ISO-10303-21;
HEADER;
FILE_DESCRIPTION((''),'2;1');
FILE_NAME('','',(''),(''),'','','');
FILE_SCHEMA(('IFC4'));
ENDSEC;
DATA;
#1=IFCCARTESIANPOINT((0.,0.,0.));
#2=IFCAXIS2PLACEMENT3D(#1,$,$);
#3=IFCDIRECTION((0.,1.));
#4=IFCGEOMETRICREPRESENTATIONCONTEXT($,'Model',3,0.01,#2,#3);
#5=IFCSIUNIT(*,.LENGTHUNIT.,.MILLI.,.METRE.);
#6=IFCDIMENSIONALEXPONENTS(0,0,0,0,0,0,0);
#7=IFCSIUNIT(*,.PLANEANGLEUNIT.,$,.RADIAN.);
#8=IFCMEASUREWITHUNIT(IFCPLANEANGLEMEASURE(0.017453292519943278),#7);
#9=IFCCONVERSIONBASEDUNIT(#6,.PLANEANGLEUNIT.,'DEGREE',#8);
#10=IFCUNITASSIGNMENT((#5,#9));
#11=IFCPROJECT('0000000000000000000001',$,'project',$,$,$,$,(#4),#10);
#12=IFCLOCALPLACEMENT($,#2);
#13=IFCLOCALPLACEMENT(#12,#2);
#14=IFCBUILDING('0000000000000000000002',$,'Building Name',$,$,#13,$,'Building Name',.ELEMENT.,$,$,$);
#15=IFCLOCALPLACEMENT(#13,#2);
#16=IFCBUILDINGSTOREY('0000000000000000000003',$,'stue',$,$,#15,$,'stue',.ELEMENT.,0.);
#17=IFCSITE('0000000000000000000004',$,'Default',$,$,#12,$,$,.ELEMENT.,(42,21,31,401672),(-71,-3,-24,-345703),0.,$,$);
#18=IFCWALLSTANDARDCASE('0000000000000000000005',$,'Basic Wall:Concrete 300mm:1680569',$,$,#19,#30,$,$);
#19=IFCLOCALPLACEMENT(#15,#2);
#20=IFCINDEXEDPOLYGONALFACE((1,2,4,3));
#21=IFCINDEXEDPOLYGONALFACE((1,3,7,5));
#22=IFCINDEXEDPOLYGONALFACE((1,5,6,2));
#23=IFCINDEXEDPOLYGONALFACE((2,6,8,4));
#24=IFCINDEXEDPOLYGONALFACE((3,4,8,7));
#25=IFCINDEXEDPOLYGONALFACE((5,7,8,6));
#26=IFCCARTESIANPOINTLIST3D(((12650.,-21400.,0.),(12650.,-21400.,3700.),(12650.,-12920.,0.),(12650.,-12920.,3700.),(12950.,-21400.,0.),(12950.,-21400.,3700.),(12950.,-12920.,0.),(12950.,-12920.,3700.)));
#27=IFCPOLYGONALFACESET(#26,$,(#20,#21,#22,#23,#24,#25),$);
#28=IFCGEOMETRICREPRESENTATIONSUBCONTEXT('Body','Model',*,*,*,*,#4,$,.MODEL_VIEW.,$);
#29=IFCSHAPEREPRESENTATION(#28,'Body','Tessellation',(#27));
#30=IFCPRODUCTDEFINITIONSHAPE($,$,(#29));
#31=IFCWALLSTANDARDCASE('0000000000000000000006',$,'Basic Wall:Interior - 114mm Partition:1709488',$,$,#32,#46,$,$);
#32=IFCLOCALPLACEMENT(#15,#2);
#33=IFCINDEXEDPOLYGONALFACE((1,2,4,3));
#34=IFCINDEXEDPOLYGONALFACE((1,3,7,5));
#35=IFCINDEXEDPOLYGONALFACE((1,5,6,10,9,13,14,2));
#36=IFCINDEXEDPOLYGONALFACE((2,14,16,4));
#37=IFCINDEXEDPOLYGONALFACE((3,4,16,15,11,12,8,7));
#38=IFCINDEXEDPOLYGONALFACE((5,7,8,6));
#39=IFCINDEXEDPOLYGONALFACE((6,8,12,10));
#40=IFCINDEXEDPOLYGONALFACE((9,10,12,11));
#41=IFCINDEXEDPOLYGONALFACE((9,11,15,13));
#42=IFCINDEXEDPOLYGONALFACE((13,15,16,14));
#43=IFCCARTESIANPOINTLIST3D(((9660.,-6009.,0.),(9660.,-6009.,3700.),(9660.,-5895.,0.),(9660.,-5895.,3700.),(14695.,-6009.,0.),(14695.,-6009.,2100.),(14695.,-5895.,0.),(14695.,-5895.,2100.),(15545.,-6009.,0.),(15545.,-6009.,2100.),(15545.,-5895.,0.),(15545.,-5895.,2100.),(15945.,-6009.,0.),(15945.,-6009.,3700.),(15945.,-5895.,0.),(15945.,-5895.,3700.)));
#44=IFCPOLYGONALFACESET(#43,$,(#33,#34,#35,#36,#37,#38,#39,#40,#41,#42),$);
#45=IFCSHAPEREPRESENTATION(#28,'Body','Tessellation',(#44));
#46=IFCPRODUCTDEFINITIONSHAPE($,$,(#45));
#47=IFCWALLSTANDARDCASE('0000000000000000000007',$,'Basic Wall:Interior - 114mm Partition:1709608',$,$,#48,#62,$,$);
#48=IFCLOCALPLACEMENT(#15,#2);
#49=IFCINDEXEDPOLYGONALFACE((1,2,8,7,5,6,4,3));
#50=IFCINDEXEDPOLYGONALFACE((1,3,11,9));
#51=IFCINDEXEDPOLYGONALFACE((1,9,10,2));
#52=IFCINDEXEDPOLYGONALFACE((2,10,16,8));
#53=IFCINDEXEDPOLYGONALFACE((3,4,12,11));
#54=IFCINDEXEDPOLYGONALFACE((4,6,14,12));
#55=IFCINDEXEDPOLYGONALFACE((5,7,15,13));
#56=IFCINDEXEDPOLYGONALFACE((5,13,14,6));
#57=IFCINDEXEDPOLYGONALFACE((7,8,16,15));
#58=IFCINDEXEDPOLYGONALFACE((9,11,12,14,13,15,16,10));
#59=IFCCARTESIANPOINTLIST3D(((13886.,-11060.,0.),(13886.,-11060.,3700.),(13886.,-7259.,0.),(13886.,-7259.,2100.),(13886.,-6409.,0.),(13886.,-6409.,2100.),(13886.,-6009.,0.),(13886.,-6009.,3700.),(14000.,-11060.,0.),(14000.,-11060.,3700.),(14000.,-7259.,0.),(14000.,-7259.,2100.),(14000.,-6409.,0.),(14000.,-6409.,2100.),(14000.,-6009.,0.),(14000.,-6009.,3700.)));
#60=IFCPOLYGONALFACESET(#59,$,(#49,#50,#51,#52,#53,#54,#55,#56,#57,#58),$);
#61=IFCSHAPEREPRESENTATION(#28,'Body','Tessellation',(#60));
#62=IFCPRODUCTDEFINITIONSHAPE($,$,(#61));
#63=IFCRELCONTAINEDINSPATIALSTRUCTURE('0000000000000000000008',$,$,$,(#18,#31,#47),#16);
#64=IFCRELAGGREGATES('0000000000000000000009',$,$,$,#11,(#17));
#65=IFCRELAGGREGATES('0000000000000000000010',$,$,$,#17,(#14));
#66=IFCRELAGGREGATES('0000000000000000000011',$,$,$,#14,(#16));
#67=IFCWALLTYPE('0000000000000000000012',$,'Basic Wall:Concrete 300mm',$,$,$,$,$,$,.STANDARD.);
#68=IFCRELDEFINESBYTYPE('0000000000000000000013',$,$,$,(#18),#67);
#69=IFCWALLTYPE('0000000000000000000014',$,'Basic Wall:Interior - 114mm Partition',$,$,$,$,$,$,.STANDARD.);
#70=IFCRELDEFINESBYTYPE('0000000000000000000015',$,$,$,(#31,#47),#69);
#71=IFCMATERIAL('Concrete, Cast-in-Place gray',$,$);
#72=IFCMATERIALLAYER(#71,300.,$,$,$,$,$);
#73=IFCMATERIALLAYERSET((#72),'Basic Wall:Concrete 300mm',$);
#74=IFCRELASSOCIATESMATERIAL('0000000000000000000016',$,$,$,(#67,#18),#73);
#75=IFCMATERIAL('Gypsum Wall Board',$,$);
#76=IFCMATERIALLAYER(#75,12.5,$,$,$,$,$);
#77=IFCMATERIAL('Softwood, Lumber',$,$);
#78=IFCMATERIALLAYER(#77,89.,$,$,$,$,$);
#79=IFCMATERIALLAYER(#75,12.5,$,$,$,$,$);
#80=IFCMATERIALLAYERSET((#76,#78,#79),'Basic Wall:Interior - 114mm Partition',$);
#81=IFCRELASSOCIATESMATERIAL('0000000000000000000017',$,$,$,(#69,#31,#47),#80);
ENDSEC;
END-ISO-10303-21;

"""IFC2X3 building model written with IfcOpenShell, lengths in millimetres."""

from ifc_helpers import new_model, entity, si_unit, converted_unit, direction, frame, frame_2d, origin, place, context, subcontext, project, spatial, polyline, rectangle, extrude, clip, bounded_halfspace, material, layer, layer_set, layer_usage, type_object, element, save


model = new_model("IFC2X3")

# Units and contexts
model_context = context("Model", 3, precision=0.01, world=origin(), true_north=direction((0.0, 1.0)))
body_context = subcontext(model_context, "Body", "Model", "MODEL_VIEW")
ifc_project = project(units=[si_unit("LENGTHUNIT", "METRE", prefix="MILLI"), converted_unit("PLANEANGLEUNIT", "DEGREE", entity("IfcPlaneAngleMeasure", 0.017453292519943278), si_unit("PLANEANGLEUNIT", "RADIAN"), dimensions=[0, 0, 0, 0, 0, 0, 0])], contexts=[model_context])

# Site, building, storey
site_placement = place(None, origin())
site = spatial("IfcSite", under=ifc_project, at=site_placement, Name="Default", CompositionType="ELEMENT", RefLatitude=(42, 21, 31, 401672), RefLongitude=(-71, -3, -24, -345703), RefElevation=0.0)
building_placement = place(site_placement, origin())
building = spatial("IfcBuilding", under=site, at=building_placement, Name="Building Name", LongName="Building Name", CompositionType="ELEMENT")
storey_placement = place(building_placement, origin())
storey = spatial("IfcBuildingStorey", under=building, at=storey_placement, Name="stue", LongName="stue", CompositionType="ELEMENT", Elevation=0.0)

# Shared definitions
ifc_material_1 = material(Name="Concrete, Cast-in-Place gray")

# Wall
ifc_layer_1 = layer(ifc_material_1, 300.0)
ifc_layer_set_1 = layer_set([ifc_layer_1], Name="Basic Wall:Concrete 300mm")
ifc_layer_usage_1 = layer_usage(ifc_layer_set_1, "AXIS2", "NEGATIVE", 150.0)
wall_type_1 = type_object("IfcWallType", Name="Basic Wall:Concrete 300mm", PredefinedType="STANDARD", material=ifc_layer_set_1)
wall_1_placement = place(storey_placement, frame((12800.0, -12920.0, 0.0), z_axis=(0.0, 0.0, 1.0), x_axis=(0.0, -1.0, 0.0)))
element("IfcWallStandardCase", 1, at=wall_1_placement, inside=storey, type_object=wall_type_1, material=ifc_layer_usage_1, Name="Basic Wall:Concrete 300mm:1680569", context=body_context, shape_type="Clipping", body=[
    clip(clip(extrude(rectangle(XDim=8480.0, YDim=300.0, at=frame_2d((4240.0, 0.0), x_axis=(-1.0, 0.0))), origin(), (0.0, 0.0, 1.0), 3700.0), bounded_halfspace(frame((0.0, -150.0, 3700.0), z_axis=(0.0, 0.0, -1.0), x_axis=(1.0, 0.0, 0.0)), True, frame((0.0, -150.0, 3700.0)), polyline([(0.0, 0.0), (130.0, 0.0), (130.0, 300.0), (0.0, 300.0), (0.0, 0.0)]))), bounded_halfspace(frame((130.0, -150.0, 3700.0), z_axis=(0.0, 0.0, -1.0), x_axis=(0.0, -1.0, 0.0)), True, frame((130.0, -150.0, 3700.0)), polyline([(0.0, 0.0), (8350.0, 0.0), (8350.0, 300.0), (0.0, 300.0), (0.0, 0.0)]))),
])

# Walls, openings
ifc_material_2 = material(Name="Gypsum Wall Board")
ifc_layer_2 = layer(ifc_material_2, 12.5)
ifc_material_3 = material(Name="Softwood, Lumber")
ifc_layer_3 = layer(ifc_material_3, 89.0)
ifc_layer_4 = layer(ifc_material_2, 12.5)
ifc_layer_set_2 = layer_set([ifc_layer_2, ifc_layer_3, ifc_layer_4], Name="Basic Wall:Interior - 114mm Partition")
ifc_layer_usage_2 = layer_usage(ifc_layer_set_2, "AXIS2", "NEGATIVE", 57.0)
wall_type_2 = type_object("IfcWallType", Name="Basic Wall:Interior - 114mm Partition", PredefinedType="STANDARD", material=ifc_layer_set_2)
wall_2_placement = place(storey_placement, frame((9660.0, -5952.0, 0.0)))
wall_2 = element("IfcWallStandardCase", 2, at=wall_2_placement, inside=storey, type_object=wall_type_2, material=ifc_layer_usage_2, Name="Basic Wall:Interior - 114mm Partition:1709488", context=body_context, shape_type="Clipping", body=[
    clip(extrude(rectangle(XDim=6285.0, YDim=114.0, at=frame_2d((3142.5, 0.0), x_axis=(1.0, 0.0))), origin(), (0.0, 0.0, 1.0), 3700.0), bounded_halfspace(frame((0.0, -57.0, 3700.0), z_axis=(0.0, 0.0, -1.0), x_axis=(0.0, -1.0, 0.0)), True, frame((0.0, -57.0, 3700.0)), polyline([(0.0, 0.0), (4226.0, 0.0), (4340.0, 0.0), (6285.0, 0.0), (6285.0, 114.0), (0.0, 114.0), (0.0, 0.0)]))),
])
opening_1_placement = place(wall_2_placement, frame((5035.0, -57.0, 0.0)))
element("IfcOpeningElement", 3, at=opening_1_placement, cuts=wall_2, ObjectType="Opening", context=body_context, shape_type="SweptSolid", body=[
    extrude(rectangle(XDim=2100.0, YDim=850.0, at=frame_2d((1050.0, 425.0), x_axis=(1.0, 0.0))), frame((0.0, 0.0, 0.0), z_axis=(0.0, 1.0, 0.0), x_axis=(0.0, 0.0, 1.0)), (0.0, 0.0, 1.0), 114.0),
])
ifc_layer_usage_3 = layer_usage(ifc_layer_set_2, "AXIS2", "NEGATIVE", 57.0)
wall_3_placement = place(storey_placement, frame((13943.0, -6009.0, 0.0), z_axis=(0.0, 0.0, 1.0), x_axis=(0.0, -1.0, 0.0)))
wall_3 = element("IfcWallStandardCase", 4, at=wall_3_placement, inside=storey, type_object=wall_type_2, material=ifc_layer_usage_3, Name="Basic Wall:Interior - 114mm Partition:1709608", context=body_context, shape_type="Clipping", body=[
    clip(extrude(rectangle(XDim=5051.0, YDim=114.0, at=frame_2d((2525.5, 0.0), x_axis=(-1.0, 0.0))), origin(), (0.0, 0.0, 1.0), 3700.0), bounded_halfspace(frame((0.0, -57.0, 3700.0), z_axis=(0.0, 0.0, -1.0), x_axis=(1.0, 0.0, 0.0)), True, frame((0.0, -57.0, 3700.0)), polyline([(0.0, 0.0), (5051.0, 0.0), (5051.0, 114.0), (0.0, 114.0), (0.0, 0.0)]))),
])
opening_2_placement = place(wall_3_placement, frame((1250.0, 57.0, 0.0)))
element("IfcOpeningElement", 5, at=opening_2_placement, cuts=wall_3, ObjectType="Opening", context=body_context, shape_type="SweptSolid", body=[
    extrude(rectangle(XDim=2100.0, YDim=850.0, at=frame_2d((1050.0, 425.0), x_axis=(1.0, 0.0))), frame((0.0, 0.0, 0.0), z_axis=(0.0, -1.0, 0.0), x_axis=(0.0, 0.0, 1.0)), (0.0, 0.0, 1.0), 114.0),
])

save(model, "model.ifc")
